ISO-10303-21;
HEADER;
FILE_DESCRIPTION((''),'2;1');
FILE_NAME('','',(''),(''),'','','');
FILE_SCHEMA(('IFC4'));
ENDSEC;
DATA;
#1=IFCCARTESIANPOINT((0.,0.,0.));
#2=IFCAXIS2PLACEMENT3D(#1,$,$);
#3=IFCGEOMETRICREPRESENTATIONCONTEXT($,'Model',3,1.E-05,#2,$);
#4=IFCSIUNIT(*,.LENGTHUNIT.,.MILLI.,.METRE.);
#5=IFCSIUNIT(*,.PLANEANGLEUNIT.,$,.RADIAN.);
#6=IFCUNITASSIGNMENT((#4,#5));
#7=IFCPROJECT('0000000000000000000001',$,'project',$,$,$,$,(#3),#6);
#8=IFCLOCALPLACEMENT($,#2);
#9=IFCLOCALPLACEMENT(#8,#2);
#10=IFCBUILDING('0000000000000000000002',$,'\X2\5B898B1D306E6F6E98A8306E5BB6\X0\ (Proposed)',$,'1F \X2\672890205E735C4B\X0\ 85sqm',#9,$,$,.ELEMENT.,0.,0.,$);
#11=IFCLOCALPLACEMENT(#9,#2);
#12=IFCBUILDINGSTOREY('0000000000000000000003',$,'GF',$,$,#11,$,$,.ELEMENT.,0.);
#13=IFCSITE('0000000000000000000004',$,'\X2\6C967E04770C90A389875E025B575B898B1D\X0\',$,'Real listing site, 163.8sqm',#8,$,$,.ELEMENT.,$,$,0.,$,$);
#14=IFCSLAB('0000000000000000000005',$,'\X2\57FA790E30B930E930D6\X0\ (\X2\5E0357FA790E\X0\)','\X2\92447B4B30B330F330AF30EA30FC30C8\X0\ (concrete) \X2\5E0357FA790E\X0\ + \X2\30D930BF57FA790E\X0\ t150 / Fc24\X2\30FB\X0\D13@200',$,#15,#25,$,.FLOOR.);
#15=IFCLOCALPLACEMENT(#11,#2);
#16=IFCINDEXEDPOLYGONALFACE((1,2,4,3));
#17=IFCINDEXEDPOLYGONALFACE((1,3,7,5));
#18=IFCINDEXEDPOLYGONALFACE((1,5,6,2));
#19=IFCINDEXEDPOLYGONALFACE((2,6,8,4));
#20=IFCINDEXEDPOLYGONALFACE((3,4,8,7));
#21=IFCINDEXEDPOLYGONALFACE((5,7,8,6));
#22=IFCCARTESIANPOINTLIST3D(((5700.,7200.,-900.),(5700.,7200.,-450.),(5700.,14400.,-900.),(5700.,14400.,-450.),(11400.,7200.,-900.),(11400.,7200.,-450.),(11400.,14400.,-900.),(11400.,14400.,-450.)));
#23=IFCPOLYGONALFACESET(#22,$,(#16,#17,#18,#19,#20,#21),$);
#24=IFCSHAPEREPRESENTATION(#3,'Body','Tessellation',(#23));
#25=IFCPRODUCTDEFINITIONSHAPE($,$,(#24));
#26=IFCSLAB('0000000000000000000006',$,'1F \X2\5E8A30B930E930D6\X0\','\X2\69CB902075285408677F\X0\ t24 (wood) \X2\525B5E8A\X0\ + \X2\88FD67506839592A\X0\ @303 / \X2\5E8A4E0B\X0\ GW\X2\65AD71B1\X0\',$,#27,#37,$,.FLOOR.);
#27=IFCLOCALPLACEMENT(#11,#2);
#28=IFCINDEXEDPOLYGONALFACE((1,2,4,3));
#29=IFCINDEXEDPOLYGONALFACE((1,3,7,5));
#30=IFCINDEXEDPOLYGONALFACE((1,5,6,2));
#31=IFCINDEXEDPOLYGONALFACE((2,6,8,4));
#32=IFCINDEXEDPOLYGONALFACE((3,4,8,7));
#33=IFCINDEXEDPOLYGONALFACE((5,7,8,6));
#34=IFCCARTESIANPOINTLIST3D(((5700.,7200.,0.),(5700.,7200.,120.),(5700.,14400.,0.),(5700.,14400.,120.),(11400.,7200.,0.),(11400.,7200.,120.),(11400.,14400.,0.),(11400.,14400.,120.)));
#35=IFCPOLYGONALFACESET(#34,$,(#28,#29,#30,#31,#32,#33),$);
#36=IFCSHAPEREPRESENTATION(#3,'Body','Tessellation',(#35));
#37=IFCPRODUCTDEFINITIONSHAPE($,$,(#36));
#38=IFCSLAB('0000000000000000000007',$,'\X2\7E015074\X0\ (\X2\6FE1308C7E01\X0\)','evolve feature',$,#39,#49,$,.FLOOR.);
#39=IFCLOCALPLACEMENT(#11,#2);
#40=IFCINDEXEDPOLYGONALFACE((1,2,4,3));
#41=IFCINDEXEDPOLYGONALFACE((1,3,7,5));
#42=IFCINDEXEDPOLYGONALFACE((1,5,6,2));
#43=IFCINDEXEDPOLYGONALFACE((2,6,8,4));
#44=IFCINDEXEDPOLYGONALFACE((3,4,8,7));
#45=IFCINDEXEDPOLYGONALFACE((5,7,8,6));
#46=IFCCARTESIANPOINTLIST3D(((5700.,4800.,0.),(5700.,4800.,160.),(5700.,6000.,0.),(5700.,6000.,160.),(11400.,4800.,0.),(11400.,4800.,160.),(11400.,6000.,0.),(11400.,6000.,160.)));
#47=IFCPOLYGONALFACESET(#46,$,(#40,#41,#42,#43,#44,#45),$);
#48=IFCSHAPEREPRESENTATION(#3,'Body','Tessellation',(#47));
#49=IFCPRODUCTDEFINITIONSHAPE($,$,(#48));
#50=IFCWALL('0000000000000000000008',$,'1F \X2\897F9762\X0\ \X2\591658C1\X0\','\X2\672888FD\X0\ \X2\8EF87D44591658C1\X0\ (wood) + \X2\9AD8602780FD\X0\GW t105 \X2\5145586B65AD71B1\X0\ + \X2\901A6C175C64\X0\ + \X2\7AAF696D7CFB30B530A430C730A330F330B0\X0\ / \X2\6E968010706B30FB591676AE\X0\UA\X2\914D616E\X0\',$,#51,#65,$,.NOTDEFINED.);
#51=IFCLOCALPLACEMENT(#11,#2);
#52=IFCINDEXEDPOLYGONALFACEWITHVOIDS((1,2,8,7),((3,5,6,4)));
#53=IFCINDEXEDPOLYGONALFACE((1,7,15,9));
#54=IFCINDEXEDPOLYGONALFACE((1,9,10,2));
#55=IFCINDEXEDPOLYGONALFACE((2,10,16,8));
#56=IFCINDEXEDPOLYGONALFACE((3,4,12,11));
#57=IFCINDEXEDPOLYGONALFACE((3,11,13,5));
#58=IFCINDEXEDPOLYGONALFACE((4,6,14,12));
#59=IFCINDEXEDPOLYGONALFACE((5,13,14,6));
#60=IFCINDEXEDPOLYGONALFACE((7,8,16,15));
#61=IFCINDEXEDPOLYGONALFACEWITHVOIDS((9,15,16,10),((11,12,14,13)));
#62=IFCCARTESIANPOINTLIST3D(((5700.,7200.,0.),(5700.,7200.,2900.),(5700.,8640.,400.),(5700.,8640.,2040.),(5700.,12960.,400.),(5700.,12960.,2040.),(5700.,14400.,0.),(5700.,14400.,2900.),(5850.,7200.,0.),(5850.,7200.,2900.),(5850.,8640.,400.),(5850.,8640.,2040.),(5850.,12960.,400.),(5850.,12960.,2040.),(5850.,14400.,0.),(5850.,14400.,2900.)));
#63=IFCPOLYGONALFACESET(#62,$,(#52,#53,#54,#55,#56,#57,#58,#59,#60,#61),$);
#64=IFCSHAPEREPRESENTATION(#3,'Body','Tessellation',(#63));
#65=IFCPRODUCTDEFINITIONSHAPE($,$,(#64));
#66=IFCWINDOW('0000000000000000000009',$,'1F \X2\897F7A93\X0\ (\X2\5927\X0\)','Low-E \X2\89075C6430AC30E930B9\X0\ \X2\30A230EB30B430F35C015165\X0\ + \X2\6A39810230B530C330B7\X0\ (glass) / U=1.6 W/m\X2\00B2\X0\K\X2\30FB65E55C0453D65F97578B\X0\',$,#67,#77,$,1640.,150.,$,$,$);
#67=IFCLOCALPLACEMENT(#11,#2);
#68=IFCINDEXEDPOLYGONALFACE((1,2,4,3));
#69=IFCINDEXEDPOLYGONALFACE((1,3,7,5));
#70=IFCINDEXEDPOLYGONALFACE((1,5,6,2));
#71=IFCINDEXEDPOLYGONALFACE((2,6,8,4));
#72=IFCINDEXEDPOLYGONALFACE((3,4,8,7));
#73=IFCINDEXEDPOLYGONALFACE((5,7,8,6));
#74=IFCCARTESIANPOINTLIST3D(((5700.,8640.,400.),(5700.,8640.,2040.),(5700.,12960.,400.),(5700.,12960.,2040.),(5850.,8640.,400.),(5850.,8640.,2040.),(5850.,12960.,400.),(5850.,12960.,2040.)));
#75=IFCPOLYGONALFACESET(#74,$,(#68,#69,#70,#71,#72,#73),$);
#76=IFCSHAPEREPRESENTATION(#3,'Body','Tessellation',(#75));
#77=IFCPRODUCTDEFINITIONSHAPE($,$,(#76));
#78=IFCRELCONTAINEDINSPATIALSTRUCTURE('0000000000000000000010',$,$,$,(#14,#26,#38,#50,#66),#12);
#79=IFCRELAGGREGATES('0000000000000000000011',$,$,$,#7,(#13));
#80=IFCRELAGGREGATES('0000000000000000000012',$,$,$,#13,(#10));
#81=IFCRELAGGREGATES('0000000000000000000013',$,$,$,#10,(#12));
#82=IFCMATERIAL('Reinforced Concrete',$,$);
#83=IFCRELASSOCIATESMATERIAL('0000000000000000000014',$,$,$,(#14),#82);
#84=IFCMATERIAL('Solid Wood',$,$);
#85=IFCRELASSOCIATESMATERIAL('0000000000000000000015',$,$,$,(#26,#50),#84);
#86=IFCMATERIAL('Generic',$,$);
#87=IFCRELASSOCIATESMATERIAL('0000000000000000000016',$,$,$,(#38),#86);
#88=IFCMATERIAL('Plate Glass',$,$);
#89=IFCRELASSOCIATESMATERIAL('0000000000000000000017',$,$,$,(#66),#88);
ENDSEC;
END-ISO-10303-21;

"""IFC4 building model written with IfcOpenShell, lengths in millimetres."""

from ifc_helpers import new_model, si_unit, frame, frame_2d, origin, place, context, project, spatial, rectangle, extrude, material, element, fill, save


model = new_model("IFC4")

# Units and contexts
model_context = context("Model", 3, precision=1e-05, world=origin())
ifc_project = project(units=[si_unit("LENGTHUNIT", "METRE", prefix="MILLI"), si_unit("PLANEANGLEUNIT", "RADIAN")], contexts=[model_context])

# Site, building, storey
site_placement = place(None, origin())
site = spatial("IfcSite", under=ifc_project, at=site_placement, Name="沖縄県那覇市字安謝", ObjectType="Real listing site, 163.8sqm", CompositionType="ELEMENT", RefElevation=0.0)
building_placement = place(site_placement, origin())
building = spatial("IfcBuilding", under=site, at=building_placement, Name="安謝の潮風の家 (Proposed)", ObjectType="1F 木造平屋 85sqm", CompositionType="ELEMENT", ElevationOfRefHeight=0.0, ElevationOfTerrain=0.0)
storey_placement = place(building_placement, origin())
storey = spatial("IfcBuildingStorey", under=building, at=storey_placement, Name="GF", CompositionType="ELEMENT", Elevation=0.0)

# Slabs
ifc_material_1 = material(Name="Reinforced Concrete")
slab_1_placement = place(storey_placement, frame((2850.0, 3600.0, -450.0)))
element("IfcSlab", 1, at=slab_1_placement, inside=storey, material=ifc_material_1, Name="基礎スラブ (布基礎)", Description="鉄筋コンクリート (concrete) 布基礎 + ベタ基礎 t150 / Fc24・D13@200", PredefinedType="FLOOR", context=model_context, shape_type="SweptSolid", body=[
    extrude(rectangle(XDim=5700.0, YDim=7200.0, at=frame_2d((2850.0, 3600.0))), frame((2850.0, 3600.0, -450.0)), (0.0, 0.0, 1.0), 450.0),
])
ifc_material_2 = material(Name="Solid Wood")
slab_2_placement = place(storey_placement, frame((2850.0, 3600.0, 0.0)))
element("IfcSlab", 2, at=slab_2_placement, inside=storey, material=ifc_material_2, Name="1F 床スラブ", Description="構造用合板 t24 (wood) 剛床 + 製材根太 @303 / 床下 GW断熱", PredefinedType="FLOOR", context=model_context, shape_type="SweptSolid", body=[
    extrude(rectangle(XDim=5700.0, YDim=7200.0, at=frame_2d((2850.0, 3600.0))), frame((2850.0, 3600.0, 0.0)), (0.0, 0.0, 1.0), 120.0),
])
ifc_material_3 = material(Name="Generic")
slab_3_placement = place(storey_placement, frame((2850.0, 2400.0, 0.0)))
element("IfcSlab", 3, at=slab_3_placement, inside=storey, material=ifc_material_3, Name="縁側 (濡れ縁)", Description="evolve feature", PredefinedType="FLOOR", context=model_context, shape_type="SweptSolid", body=[
    extrude(rectangle(XDim=5700.0, YDim=1200.0, at=frame_2d((2850.0, 600.0))), frame((2850.0, 2400.0, 0.0)), (0.0, 0.0, 1.0), 160.0),
])

# Shared definitions
ifc_material_4 = material(Name="Plate Glass")

# Wall, opening, window
wall_1_placement = place(storey_placement, frame((2850.0, 3600.0, 0.0)))
wall_1 = element("IfcWall", 4, at=wall_1_placement, inside=storey, material=ifc_material_2, Name="1F 西面 外壁", Description="木製 軸組外壁 (wood) + 高性能GW t105 充填断熱 + 通気層 + 窯業系サイディング / 準耐火・外皮UA配慮", PredefinedType="NOTDEFINED", context=model_context, shape_type="SweptSolid", body=[
    extrude(rectangle(XDim=150.0, YDim=7200.0, at=frame_2d((75.0, 3600.0))), frame((2850.0, 3600.0, 0.0)), (0.0, 0.0, 1.0), 2900.0),
])
opening_1_placement = place(storey_placement, frame((2850.0, 4320.0, 200.0)))
opening_1 = element("IfcOpeningElement", 5, at=opening_1_placement, cuts=wall_1, PredefinedType="NOTDEFINED", context=model_context, shape_type="SweptSolid", body=[
    extrude(rectangle(XDim=150.0, YDim=4320.0, at=frame_2d((75.0, 2160.0))), frame((2850.0, 4320.0, 200.0)), (0.0, 0.0, 1.0), 1640.0),
])
window_1_placement = place(storey_placement, frame((2850.0, 4320.0, 200.0)))
window_1 = element("IfcWindow", 6, at=window_1_placement, inside=storey, material=ifc_material_4, Name="1F 西窓 (大)", Description="Low-E 複層ガラス アルゴン封入 + 樹脂サッシ (glass) / U=1.6 W/m²K・日射取得型", OverallHeight=1640.0, OverallWidth=150.0, context=model_context, shape_type="SweptSolid", body=[
    extrude(rectangle(XDim=150.0, YDim=4320.0, at=frame_2d((75.0, 2160.0))), frame((2850.0, 4320.0, 200.0)), (0.0, 0.0, 1.0), 1640.0),
])
fill(opening_1, window_1)

save(model, "model.ifc")
